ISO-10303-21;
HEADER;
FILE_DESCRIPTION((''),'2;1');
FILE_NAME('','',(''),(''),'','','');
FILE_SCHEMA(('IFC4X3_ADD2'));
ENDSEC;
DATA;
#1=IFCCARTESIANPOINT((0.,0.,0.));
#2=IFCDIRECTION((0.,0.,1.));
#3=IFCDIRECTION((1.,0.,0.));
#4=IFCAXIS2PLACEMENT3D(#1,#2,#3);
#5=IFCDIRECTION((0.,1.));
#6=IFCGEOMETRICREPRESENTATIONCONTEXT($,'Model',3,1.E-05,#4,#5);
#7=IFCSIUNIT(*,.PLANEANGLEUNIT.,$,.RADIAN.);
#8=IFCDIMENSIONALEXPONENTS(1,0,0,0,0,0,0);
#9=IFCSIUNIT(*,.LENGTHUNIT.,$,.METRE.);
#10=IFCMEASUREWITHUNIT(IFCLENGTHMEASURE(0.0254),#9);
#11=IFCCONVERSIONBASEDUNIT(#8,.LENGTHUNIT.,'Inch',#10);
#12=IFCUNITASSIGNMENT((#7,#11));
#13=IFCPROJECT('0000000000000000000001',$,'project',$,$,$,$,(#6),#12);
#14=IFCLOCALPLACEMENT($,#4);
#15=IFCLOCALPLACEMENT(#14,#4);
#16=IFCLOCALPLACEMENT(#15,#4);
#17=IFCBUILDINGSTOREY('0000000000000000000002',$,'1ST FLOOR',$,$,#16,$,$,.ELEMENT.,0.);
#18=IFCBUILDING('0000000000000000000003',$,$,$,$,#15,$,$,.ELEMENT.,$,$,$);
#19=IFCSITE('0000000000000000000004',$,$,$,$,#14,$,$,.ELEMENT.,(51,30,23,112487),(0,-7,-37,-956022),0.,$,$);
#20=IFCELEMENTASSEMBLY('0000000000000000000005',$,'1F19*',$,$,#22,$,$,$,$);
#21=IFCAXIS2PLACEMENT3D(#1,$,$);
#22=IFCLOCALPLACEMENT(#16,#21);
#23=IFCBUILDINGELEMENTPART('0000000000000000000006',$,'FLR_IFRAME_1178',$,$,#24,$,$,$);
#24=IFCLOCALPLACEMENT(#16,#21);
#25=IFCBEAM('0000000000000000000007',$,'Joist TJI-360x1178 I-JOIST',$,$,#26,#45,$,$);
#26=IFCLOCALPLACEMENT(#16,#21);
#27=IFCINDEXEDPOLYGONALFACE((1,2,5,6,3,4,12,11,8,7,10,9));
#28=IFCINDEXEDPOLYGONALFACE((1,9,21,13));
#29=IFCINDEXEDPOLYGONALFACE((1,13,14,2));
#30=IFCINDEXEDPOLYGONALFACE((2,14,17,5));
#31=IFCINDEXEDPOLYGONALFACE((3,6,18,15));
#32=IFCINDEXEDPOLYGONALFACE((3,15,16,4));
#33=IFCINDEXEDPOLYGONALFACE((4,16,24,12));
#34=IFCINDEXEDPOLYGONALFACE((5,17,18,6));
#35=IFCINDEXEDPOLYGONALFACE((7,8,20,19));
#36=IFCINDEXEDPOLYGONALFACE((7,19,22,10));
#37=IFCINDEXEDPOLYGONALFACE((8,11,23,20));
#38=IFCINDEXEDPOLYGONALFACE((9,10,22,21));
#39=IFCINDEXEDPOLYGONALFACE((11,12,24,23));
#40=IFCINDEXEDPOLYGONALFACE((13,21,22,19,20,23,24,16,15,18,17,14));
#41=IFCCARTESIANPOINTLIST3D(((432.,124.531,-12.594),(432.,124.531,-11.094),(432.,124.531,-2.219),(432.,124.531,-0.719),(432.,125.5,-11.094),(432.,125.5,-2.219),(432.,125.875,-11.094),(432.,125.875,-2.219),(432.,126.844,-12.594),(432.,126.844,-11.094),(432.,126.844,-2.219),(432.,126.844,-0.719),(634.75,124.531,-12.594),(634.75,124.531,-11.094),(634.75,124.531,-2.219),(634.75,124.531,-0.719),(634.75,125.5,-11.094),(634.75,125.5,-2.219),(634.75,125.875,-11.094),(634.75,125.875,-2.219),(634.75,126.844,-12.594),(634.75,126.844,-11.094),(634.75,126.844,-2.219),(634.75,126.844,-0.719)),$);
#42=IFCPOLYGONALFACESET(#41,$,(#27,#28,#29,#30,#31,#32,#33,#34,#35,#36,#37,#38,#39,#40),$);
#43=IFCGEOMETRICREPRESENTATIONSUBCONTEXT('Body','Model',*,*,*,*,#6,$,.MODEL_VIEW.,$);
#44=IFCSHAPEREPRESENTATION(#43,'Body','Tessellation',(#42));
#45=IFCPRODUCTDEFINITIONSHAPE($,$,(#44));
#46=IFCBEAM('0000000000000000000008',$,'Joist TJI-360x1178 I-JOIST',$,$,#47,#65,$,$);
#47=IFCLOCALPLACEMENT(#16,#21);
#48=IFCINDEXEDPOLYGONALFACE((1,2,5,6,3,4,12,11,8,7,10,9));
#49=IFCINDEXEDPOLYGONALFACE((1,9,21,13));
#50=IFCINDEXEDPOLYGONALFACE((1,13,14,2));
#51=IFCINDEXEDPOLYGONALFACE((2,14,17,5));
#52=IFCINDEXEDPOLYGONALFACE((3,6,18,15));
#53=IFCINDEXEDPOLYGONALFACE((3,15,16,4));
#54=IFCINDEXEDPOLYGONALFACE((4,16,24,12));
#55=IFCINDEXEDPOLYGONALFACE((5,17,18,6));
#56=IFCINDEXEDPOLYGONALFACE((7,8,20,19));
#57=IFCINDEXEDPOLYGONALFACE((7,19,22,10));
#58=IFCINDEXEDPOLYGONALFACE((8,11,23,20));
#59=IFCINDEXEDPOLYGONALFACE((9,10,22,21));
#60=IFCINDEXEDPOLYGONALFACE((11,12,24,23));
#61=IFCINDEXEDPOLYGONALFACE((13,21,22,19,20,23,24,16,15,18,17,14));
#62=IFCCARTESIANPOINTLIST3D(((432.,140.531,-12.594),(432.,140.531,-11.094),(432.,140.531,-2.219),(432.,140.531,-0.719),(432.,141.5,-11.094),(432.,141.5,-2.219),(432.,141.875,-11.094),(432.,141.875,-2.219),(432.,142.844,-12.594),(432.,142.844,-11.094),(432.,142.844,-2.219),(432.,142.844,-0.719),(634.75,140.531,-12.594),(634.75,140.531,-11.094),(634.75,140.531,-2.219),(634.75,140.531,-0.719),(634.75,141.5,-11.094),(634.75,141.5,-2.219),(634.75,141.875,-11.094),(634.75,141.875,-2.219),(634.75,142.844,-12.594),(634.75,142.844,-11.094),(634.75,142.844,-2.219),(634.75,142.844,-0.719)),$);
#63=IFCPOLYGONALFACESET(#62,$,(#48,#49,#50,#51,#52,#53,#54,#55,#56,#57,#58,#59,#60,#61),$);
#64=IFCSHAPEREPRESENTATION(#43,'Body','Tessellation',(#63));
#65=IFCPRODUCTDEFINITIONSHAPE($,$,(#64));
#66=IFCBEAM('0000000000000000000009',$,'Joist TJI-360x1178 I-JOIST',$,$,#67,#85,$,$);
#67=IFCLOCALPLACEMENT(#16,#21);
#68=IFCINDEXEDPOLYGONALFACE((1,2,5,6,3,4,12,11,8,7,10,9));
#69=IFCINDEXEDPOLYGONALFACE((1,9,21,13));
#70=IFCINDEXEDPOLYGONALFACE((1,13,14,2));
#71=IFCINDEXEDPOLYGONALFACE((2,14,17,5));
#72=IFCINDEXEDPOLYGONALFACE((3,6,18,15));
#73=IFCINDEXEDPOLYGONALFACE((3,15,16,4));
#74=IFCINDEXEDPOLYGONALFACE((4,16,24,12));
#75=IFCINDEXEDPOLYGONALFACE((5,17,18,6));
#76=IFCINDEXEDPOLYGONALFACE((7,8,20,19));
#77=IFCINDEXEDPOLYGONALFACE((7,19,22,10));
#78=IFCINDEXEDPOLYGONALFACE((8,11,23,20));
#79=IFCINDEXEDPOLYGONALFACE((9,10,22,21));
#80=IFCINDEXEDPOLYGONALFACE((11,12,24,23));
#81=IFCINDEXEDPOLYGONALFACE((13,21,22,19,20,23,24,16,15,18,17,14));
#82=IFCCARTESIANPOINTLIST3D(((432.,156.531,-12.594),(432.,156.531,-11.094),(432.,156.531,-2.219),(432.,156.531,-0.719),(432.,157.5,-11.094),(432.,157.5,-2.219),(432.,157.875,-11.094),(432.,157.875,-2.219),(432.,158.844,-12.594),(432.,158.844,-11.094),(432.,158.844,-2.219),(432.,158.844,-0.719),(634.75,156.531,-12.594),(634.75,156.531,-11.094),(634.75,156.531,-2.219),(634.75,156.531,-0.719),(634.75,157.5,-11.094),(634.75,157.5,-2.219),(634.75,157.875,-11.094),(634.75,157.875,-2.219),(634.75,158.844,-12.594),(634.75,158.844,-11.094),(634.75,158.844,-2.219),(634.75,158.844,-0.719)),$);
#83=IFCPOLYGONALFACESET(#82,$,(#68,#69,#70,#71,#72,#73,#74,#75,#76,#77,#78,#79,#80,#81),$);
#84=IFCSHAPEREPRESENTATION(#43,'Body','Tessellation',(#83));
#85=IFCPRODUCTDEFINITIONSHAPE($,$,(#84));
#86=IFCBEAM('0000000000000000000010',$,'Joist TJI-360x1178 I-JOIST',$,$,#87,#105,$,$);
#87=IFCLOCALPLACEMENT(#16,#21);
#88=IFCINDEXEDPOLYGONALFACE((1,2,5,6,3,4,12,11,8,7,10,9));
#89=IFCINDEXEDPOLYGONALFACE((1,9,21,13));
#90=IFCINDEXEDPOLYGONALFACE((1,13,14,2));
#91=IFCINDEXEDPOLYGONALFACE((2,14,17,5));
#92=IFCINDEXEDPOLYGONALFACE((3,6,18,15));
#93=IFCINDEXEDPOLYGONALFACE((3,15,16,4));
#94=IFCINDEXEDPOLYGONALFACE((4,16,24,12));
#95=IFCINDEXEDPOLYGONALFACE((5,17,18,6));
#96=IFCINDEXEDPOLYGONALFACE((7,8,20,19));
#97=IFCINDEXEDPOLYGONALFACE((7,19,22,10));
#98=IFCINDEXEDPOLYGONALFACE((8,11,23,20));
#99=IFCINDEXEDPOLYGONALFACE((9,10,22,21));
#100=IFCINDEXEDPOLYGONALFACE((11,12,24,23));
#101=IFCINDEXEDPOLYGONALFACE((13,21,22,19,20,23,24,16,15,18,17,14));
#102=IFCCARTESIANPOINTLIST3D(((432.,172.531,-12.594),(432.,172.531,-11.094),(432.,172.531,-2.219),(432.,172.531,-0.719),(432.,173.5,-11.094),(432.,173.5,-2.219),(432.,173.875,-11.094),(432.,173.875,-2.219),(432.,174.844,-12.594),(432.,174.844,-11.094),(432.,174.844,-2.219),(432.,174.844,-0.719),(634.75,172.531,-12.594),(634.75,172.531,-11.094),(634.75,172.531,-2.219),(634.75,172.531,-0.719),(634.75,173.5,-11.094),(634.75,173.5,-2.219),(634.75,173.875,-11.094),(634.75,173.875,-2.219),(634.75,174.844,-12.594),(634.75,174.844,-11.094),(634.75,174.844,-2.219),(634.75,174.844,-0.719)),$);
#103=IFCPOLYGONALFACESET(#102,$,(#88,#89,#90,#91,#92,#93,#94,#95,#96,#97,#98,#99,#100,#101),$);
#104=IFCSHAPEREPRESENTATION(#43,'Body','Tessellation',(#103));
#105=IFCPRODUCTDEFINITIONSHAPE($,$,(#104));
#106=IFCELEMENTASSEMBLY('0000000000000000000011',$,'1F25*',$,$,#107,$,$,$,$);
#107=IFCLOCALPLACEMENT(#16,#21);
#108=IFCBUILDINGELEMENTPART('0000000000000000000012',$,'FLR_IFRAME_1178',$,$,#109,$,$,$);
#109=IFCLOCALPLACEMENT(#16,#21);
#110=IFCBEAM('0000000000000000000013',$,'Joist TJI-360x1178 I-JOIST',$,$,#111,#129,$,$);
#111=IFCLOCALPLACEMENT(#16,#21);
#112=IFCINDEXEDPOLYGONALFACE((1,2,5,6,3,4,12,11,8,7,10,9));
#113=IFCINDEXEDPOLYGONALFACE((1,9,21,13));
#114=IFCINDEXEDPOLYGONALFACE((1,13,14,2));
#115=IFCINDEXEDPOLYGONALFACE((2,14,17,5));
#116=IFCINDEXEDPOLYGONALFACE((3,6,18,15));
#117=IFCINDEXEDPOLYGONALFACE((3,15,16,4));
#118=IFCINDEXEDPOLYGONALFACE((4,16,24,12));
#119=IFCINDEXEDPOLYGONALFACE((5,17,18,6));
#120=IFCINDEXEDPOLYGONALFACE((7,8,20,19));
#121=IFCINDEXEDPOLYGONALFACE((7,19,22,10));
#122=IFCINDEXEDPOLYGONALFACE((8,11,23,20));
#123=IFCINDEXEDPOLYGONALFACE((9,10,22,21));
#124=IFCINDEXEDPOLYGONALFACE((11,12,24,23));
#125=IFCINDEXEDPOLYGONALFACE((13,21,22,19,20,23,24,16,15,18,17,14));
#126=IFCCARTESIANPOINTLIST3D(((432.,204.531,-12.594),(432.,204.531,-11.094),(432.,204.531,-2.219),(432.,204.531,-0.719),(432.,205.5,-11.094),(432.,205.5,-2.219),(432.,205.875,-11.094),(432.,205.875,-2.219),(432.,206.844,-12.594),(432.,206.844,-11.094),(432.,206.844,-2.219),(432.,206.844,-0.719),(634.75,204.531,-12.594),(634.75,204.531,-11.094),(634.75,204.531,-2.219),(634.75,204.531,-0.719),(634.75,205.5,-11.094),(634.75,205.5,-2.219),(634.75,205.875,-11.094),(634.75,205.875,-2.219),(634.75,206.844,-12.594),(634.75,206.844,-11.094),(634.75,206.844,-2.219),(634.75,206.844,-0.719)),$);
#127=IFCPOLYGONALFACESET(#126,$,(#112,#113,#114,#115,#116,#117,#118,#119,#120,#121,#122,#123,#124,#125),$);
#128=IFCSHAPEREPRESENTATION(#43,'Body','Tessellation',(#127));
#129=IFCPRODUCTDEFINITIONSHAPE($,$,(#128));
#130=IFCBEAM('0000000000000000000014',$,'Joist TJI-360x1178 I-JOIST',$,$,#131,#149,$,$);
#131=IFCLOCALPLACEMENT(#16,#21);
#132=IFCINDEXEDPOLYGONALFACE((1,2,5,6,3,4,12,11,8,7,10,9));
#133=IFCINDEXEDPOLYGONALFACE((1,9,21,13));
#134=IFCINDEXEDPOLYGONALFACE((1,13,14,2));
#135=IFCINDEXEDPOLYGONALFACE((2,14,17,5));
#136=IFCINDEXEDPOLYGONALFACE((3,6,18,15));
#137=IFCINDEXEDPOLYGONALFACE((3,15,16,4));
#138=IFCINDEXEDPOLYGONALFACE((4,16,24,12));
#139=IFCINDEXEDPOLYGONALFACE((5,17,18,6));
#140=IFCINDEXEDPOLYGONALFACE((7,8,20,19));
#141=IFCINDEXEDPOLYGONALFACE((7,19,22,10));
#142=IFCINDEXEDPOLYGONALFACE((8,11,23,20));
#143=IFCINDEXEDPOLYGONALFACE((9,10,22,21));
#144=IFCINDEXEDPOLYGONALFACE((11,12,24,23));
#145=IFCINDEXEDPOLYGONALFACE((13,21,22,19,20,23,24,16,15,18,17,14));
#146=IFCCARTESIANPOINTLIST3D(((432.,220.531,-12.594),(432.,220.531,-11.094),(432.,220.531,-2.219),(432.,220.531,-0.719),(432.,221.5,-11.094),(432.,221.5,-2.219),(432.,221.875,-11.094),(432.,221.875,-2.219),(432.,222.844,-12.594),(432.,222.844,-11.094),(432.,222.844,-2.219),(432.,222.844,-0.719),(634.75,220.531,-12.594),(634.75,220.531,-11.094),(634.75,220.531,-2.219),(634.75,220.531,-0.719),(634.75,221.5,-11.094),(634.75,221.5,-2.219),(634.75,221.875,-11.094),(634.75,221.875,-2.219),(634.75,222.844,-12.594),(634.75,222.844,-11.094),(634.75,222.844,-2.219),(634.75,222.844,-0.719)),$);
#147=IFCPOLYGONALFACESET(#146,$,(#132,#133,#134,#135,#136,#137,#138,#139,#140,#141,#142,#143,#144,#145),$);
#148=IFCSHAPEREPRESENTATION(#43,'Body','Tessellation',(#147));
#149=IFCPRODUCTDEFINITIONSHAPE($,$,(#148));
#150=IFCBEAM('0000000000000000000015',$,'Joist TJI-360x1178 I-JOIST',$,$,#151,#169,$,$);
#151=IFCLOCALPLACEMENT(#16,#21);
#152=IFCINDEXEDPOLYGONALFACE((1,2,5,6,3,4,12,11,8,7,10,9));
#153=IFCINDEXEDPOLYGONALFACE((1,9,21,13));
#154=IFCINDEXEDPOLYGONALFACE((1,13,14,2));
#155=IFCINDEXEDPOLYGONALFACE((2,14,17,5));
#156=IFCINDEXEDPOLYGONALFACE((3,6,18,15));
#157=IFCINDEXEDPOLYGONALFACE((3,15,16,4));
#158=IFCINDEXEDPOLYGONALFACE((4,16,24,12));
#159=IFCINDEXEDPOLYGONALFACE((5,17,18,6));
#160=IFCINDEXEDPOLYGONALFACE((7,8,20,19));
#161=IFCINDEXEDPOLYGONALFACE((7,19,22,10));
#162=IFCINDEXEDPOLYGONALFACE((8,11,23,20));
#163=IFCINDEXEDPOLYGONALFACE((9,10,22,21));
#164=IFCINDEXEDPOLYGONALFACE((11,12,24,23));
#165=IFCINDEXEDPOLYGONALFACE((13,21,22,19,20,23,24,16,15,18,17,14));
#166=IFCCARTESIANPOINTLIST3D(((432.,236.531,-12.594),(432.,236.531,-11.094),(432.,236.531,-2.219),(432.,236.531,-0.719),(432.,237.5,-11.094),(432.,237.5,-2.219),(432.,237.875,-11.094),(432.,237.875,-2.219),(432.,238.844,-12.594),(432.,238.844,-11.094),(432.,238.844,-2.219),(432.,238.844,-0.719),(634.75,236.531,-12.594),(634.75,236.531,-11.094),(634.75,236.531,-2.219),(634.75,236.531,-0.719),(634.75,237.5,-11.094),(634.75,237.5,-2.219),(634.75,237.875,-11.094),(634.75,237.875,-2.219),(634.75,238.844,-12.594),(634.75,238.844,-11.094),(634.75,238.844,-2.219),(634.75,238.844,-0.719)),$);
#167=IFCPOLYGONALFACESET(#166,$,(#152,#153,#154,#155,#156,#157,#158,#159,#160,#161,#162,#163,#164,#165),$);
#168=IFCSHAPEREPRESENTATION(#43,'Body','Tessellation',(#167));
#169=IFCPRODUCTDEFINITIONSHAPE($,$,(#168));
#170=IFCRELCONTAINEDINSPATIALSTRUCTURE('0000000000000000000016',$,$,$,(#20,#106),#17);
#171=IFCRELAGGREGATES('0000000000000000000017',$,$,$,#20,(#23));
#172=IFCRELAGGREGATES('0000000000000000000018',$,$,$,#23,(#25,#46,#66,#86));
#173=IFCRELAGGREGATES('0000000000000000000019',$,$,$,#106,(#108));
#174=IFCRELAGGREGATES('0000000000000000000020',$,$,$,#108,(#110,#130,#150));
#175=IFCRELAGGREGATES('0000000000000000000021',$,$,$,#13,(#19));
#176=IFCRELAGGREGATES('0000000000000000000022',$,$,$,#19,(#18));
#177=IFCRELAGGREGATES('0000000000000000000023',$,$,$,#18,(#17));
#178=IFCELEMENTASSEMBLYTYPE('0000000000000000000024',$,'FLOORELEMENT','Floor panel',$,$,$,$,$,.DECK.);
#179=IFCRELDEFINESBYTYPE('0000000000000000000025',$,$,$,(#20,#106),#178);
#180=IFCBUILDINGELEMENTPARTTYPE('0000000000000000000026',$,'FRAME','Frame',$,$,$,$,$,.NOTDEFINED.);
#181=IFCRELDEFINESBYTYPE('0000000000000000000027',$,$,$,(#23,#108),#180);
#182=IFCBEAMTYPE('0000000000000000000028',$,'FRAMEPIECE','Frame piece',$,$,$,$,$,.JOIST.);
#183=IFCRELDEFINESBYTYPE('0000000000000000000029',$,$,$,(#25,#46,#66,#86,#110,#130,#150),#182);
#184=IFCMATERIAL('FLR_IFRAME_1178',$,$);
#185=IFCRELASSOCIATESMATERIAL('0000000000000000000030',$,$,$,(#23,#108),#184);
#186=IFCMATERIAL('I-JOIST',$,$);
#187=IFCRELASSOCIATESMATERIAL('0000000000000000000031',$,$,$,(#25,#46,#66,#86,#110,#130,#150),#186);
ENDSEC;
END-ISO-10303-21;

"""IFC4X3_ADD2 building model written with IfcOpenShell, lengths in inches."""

from ifc_helpers import new_model, entity, si_unit, converted_unit, direction, frame, origin_with_axes, origin_2d_with_axis, place, context, subcontext, project, spatial, i_section, extrude, material, type_object, element, aggregate, save


model = new_model("IFC4X3_ADD2")

# Units and contexts
model_context = context("Model", 3, precision=1e-05, world=origin_with_axes(), true_north=direction((0.0, 1.0)))
body_context = subcontext(model_context, "Body", "Model", "MODEL_VIEW")
ifc_project = project(units=[si_unit("PLANEANGLEUNIT", "RADIAN"), converted_unit("LENGTHUNIT", "Inch", entity("IfcLengthMeasure", 0.0254), si_unit("LENGTHUNIT", "METRE"), dimensions=[1, 0, 0, 0, 0, 0, 0])], contexts=[model_context])

# Site, building, storey
site_placement = place(None, origin_with_axes())
site = spatial("IfcSite", under=ifc_project, at=site_placement, CompositionType="ELEMENT", RefLatitude=(51, 30, 23, 112487), RefLongitude=(0, -7, -37, -956022), RefElevation=0.0)
building_placement = place(site_placement, origin_with_axes())
building = spatial("IfcBuilding", under=site, at=building_placement, CompositionType="ELEMENT")
storey_placement = place(building_placement, origin_with_axes())
storey = spatial("IfcBuildingStorey", under=building, at=storey_placement, Name="1ST FLOOR", CompositionType="ELEMENT", Elevation=0.0)

# Shared definitions
building_element_part_type = type_object("IfcBuildingElementPartType", Name="FRAME", Description="Frame", PredefinedType="NOTDEFINED")

# Element assemblies, building element parts, beams
element_assembly_type_1 = type_object("IfcElementAssemblyType", Name="FLOORELEMENT", Description="Floor panel", PredefinedType="DECK")
assembly_1_placement = place(storey_placement, origin_with_axes())
assembly_1 = element("IfcElementAssembly", 1, at=assembly_1_placement, inside=storey, type_object=element_assembly_type_1, Name="1F19*")
ifc_material_1 = material(Name="FLR_IFRAME_1178")
building_element_part_1_placement = place(storey_placement, origin_with_axes())
building_element_part_1 = element("IfcBuildingElementPart", 2, at=building_element_part_1_placement, type_object=building_element_part_type, material=ifc_material_1, Name="FLR_IFRAME_1178")
aggregate(assembly_1, [building_element_part_1])
ifc_material_2 = material(Name="I-JOIST")
beam_type_1 = type_object("IfcBeamType", Name="FRAMEPIECE", Description="Frame piece", PredefinedType="JOIST")
beam_1_placement = place(storey_placement, frame((432.0, 125.688, -6.656), z_axis=(1.0, 0.0, 0.0), x_axis=(0.0, 1.0, 0.0)))
beam_1 = element("IfcBeam", 3, at=beam_1_placement, type_object=beam_type_1, material=ifc_material_2, Name="Joist TJI-360x1178 I-JOIST", context=body_context, shape_type="SweptSolid", body=[
    extrude(i_section(OverallWidth=2.313, OverallDepth=11.875, WebThickness=0.375, FlangeThickness=1.5, at=origin_2d_with_axis()), origin_with_axes(), (0.0, 0.0, 1.0), 202.75),
])
beam_2_placement = place(storey_placement, frame((432.0, 141.688, -6.656), z_axis=(1.0, 0.0, 0.0), x_axis=(0.0, 1.0, 0.0)))
beam_2 = element("IfcBeam", 4, at=beam_2_placement, type_object=beam_type_1, material=ifc_material_2, Name="Joist TJI-360x1178 I-JOIST", context=body_context, shape_type="SweptSolid", body=[
    extrude(i_section(OverallWidth=2.313, OverallDepth=11.875, WebThickness=0.375, FlangeThickness=1.5, at=origin_2d_with_axis()), origin_with_axes(), (0.0, 0.0, 1.0), 202.75),
])
beam_3_placement = place(storey_placement, frame((432.0, 157.688, -6.656), z_axis=(1.0, 0.0, 0.0), x_axis=(0.0, 1.0, 0.0)))
beam_3 = element("IfcBeam", 5, at=beam_3_placement, type_object=beam_type_1, material=ifc_material_2, Name="Joist TJI-360x1178 I-JOIST", context=body_context, shape_type="SweptSolid", body=[
    extrude(i_section(OverallWidth=2.313, OverallDepth=11.875, WebThickness=0.375, FlangeThickness=1.5, at=origin_2d_with_axis()), origin_with_axes(), (0.0, 0.0, 1.0), 202.75),
])
beam_4_placement = place(storey_placement, frame((432.0, 173.688, -6.656), z_axis=(1.0, 0.0, 0.0), x_axis=(0.0, 1.0, 0.0)))
beam_4 = element("IfcBeam", 6, at=beam_4_placement, type_object=beam_type_1, material=ifc_material_2, Name="Joist TJI-360x1178 I-JOIST", context=body_context, shape_type="SweptSolid", body=[
    extrude(i_section(OverallWidth=2.313, OverallDepth=11.875, WebThickness=0.375, FlangeThickness=1.5, at=origin_2d_with_axis()), origin_with_axes(), (0.0, 0.0, 1.0), 202.75),
])
aggregate(building_element_part_1, [beam_1, beam_2, beam_3, beam_4])
assembly_2_placement = place(storey_placement, origin_with_axes())
assembly_2 = element("IfcElementAssembly", 7, at=assembly_2_placement, inside=storey, type_object=element_assembly_type_1, Name="1F25*")
building_element_part_2_placement = place(storey_placement, origin_with_axes())
building_element_part_2 = element("IfcBuildingElementPart", 8, at=building_element_part_2_placement, type_object=building_element_part_type, material=ifc_material_1, Name="FLR_IFRAME_1178")
aggregate(assembly_2, [building_element_part_2])
beam_5_placement = place(storey_placement, frame((432.0, 205.688, -6.656), z_axis=(1.0, 0.0, 0.0), x_axis=(0.0, 1.0, 0.0)))
beam_5 = element("IfcBeam", 9, at=beam_5_placement, type_object=beam_type_1, material=ifc_material_2, Name="Joist TJI-360x1178 I-JOIST", context=body_context, shape_type="SweptSolid", body=[
    extrude(i_section(OverallWidth=2.313, OverallDepth=11.875, WebThickness=0.375, FlangeThickness=1.5, at=origin_2d_with_axis()), origin_with_axes(), (0.0, 0.0, 1.0), 202.75),
])
beam_6_placement = place(storey_placement, frame((432.0, 221.688, -6.656), z_axis=(1.0, 0.0, 0.0), x_axis=(0.0, 1.0, 0.0)))
beam_6 = element("IfcBeam", 10, at=beam_6_placement, type_object=beam_type_1, material=ifc_material_2, Name="Joist TJI-360x1178 I-JOIST", context=body_context, shape_type="SweptSolid", body=[
    extrude(i_section(OverallWidth=2.313, OverallDepth=11.875, WebThickness=0.375, FlangeThickness=1.5, at=origin_2d_with_axis()), origin_with_axes(), (0.0, 0.0, 1.0), 202.75),
])
beam_7_placement = place(storey_placement, frame((432.0, 237.688, -6.656), z_axis=(1.0, 0.0, 0.0), x_axis=(0.0, 1.0, 0.0)))
beam_7 = element("IfcBeam", 11, at=beam_7_placement, type_object=beam_type_1, material=ifc_material_2, Name="Joist TJI-360x1178 I-JOIST", context=body_context, shape_type="SweptSolid", body=[
    extrude(i_section(OverallWidth=2.313, OverallDepth=11.875, WebThickness=0.375, FlangeThickness=1.5, at=origin_2d_with_axis()), origin_with_axes(), (0.0, 0.0, 1.0), 202.75),
])
aggregate(building_element_part_2, [beam_5, beam_6, beam_7])

save(model, "model.ifc")
